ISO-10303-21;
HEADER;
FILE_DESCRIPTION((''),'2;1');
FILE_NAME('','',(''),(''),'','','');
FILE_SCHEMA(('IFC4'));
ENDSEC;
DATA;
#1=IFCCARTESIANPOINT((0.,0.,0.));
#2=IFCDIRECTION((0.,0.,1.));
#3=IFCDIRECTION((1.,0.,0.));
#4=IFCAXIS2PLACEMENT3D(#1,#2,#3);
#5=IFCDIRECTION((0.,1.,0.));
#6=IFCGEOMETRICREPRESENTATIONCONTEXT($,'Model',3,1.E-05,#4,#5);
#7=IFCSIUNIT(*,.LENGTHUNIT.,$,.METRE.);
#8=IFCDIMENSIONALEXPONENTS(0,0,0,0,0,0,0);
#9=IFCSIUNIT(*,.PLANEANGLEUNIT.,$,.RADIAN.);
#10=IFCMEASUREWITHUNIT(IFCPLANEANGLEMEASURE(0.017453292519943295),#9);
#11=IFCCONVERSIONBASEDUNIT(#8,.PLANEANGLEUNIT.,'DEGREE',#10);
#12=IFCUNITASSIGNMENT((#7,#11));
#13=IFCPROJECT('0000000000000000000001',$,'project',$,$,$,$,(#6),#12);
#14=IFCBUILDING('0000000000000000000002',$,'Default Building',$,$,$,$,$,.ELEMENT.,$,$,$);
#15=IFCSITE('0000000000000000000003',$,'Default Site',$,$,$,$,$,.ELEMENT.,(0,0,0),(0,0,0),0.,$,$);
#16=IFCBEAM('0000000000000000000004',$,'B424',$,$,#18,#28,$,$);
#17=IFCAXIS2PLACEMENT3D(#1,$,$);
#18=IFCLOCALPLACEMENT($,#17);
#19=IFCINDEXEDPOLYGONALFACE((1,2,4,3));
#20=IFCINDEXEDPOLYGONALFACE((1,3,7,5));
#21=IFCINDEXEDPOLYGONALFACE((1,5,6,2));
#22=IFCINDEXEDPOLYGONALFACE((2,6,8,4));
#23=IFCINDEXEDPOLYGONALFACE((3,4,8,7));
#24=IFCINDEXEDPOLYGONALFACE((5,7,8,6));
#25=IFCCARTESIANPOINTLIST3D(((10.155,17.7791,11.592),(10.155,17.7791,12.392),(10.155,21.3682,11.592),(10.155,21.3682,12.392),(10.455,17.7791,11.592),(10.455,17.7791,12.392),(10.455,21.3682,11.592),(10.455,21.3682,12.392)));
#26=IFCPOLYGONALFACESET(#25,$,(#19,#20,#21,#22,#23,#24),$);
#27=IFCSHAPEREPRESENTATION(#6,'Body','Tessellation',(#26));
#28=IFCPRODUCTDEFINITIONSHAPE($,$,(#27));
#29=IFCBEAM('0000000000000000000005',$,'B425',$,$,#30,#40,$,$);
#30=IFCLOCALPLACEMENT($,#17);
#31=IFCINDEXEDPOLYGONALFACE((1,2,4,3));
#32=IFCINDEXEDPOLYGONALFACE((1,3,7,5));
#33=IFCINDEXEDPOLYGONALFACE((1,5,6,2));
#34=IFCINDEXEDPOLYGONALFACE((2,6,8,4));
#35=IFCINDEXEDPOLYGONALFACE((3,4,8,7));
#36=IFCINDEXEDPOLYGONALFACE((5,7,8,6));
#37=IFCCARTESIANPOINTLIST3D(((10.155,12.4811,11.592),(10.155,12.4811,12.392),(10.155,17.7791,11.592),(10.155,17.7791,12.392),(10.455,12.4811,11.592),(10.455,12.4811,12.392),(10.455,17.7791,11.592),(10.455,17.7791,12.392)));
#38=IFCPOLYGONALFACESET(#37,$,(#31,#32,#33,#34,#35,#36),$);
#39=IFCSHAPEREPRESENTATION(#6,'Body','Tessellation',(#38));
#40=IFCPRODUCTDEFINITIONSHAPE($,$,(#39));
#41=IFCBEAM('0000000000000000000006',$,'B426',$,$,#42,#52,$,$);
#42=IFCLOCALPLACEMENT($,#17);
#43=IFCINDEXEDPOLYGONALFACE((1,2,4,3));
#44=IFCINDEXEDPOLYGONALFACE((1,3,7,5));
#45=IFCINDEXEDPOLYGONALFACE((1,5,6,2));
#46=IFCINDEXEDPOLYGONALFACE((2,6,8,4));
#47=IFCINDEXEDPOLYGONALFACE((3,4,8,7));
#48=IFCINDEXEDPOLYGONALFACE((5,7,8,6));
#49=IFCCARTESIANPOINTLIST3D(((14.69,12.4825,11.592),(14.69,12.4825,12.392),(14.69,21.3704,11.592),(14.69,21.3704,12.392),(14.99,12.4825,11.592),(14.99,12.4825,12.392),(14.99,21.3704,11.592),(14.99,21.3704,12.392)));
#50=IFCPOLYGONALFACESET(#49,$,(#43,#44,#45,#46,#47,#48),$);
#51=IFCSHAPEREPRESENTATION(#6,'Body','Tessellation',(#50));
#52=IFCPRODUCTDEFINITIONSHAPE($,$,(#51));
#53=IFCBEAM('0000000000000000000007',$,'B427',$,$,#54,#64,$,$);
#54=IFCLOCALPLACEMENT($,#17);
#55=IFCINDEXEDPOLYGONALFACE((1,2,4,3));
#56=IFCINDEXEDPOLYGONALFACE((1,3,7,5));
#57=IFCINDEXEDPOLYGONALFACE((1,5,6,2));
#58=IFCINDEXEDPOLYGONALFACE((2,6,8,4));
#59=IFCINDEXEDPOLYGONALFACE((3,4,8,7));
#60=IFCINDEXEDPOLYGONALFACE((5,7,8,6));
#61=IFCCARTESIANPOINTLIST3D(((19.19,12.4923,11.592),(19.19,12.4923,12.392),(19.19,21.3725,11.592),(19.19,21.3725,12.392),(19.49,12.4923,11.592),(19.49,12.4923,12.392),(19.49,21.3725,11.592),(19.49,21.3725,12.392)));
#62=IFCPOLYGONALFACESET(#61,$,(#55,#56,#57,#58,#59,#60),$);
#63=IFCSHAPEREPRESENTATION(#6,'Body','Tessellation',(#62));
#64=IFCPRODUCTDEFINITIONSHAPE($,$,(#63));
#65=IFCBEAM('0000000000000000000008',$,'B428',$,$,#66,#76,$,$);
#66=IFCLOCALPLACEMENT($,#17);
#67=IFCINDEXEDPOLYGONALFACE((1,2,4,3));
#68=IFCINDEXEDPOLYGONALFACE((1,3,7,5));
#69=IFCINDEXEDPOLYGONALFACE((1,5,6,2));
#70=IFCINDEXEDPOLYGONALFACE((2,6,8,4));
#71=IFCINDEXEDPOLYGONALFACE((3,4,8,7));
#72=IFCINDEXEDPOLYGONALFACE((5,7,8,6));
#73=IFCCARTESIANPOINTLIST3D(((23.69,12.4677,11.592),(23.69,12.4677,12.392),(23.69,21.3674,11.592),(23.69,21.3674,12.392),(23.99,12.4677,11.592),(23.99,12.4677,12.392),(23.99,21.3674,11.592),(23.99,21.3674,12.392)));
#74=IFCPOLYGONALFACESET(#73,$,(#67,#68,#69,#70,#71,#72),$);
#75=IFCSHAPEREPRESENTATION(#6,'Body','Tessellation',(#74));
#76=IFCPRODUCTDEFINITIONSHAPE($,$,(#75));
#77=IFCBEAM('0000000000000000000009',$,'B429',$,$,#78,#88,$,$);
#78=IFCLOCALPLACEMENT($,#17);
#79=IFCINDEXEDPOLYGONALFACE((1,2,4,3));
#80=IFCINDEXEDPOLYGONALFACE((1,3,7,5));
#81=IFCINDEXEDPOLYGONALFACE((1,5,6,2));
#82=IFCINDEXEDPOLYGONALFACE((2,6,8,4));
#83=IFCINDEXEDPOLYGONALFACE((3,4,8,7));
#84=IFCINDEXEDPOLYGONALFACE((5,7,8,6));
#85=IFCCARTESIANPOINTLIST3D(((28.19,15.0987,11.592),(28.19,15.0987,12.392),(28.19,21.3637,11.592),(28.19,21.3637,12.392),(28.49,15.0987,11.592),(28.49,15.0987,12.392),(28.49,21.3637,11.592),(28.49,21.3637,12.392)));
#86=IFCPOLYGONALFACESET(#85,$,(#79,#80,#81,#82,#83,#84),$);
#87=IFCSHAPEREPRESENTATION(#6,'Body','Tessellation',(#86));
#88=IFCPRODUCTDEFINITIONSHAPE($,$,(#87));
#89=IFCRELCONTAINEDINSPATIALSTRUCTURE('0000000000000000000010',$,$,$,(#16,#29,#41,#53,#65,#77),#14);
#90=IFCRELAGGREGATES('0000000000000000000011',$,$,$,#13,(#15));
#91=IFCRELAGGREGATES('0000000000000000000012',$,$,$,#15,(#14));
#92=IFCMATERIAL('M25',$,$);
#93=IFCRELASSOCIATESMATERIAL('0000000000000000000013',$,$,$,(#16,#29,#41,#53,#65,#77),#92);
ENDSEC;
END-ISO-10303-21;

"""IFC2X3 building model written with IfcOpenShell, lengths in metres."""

from ifc_helpers import new_model, entity, si_unit, converted_unit, direction, frame, frame_2d, origin_with_axes, place, context, project, spatial, rectangle, extrude, material, element, save


model = new_model("IFC2X3")

# Units and contexts
model_context = context("Model", 3, precision=1e-05, world=origin_with_axes(), true_north=direction((0.0, 1.0, 0.0)))
ifc_project = project(units=[si_unit("LENGTHUNIT", "METRE"), converted_unit("PLANEANGLEUNIT", "DEGREE", entity("IfcPlaneAngleMeasure", 0.017453292519943295), si_unit("PLANEANGLEUNIT", "RADIAN"), dimensions=[0, 0, 0, 0, 0, 0, 0])], contexts=[model_context])

# Site, building
site = spatial("IfcSite", under=ifc_project, Name="Default Site", CompositionType="ELEMENT", RefLatitude=(0, 0, 0), RefLongitude=(0, 0, 0), RefElevation=0.0)
building = spatial("IfcBuilding", under=site, Name="Default Building", CompositionType="ELEMENT")

# Beams
ifc_material = material(Name="M25")
placement = place(None, origin_with_axes())
element("IfcBeam", 1, at=placement, inside=building, material=ifc_material, Name="B424", context=model_context, shape_type="SweptSolid", body=[
    extrude(rectangle(XDim=0.3, YDim=0.8, at=frame_2d((0.0, 0.0), x_axis=(0.0, 1.0, 0.0))), frame((10.305, 21.3682, 11.992), z_axis=(0.0, -1.0, 0.0), x_axis=(0.0, 0.0, -1.0)), (0.0, 0.0, 1.0), 3.5891),
])
element("IfcBeam", 2, at=placement, inside=building, material=ifc_material, Name="B425", context=model_context, shape_type="SweptSolid", body=[
    extrude(rectangle(XDim=0.3, YDim=0.8, at=frame_2d((0.0, 0.0), x_axis=(0.0, 1.0, 0.0))), frame((10.305, 17.7791, 11.992), z_axis=(0.0, -1.0, 0.0), x_axis=(0.0, 0.0, -1.0)), (0.0, 0.0, 1.0), 5.298),
])
element("IfcBeam", 3, at=placement, inside=building, material=ifc_material, Name="B426", context=model_context, shape_type="SweptSolid", body=[
    extrude(rectangle(XDim=0.3, YDim=0.8, at=frame_2d((0.0, 0.0), x_axis=(0.0, 1.0, 0.0))), frame((14.84, 21.3704, 11.992), z_axis=(0.0, -1.0, 0.0), x_axis=(0.0, 0.0, -1.0)), (0.0, 0.0, 1.0), 8.8879),
])
element("IfcBeam", 4, at=placement, inside=building, material=ifc_material, Name="B427", context=model_context, shape_type="SweptSolid", body=[
    extrude(rectangle(XDim=0.3, YDim=0.8, at=frame_2d((0.0, 0.0), x_axis=(0.0, 1.0, 0.0))), frame((19.34, 21.3725, 11.992), z_axis=(0.0, -1.0, 0.0), x_axis=(0.0, 0.0, -1.0)), (0.0, 0.0, 1.0), 8.8802),
])
element("IfcBeam", 5, at=placement, inside=building, material=ifc_material, Name="B428", context=model_context, shape_type="SweptSolid", body=[
    extrude(rectangle(XDim=0.3, YDim=0.8, at=frame_2d((0.0, 0.0), x_axis=(0.0, 1.0, 0.0))), frame((23.84, 21.3674, 11.992), z_axis=(0.0, -1.0, 0.0), x_axis=(0.0, 0.0, -1.0)), (0.0, 0.0, 1.0), 8.8997),
])
element("IfcBeam", 6, at=placement, inside=building, material=ifc_material, Name="B429", context=model_context, shape_type="SweptSolid", body=[
    extrude(rectangle(XDim=0.3, YDim=0.8, at=frame_2d((0.0, 0.0), x_axis=(0.0, 1.0, 0.0))), frame((28.34, 21.3637, 11.992), z_axis=(0.0, -1.0, 0.0), x_axis=(0.0, 0.0, -1.0)), (0.0, 0.0, 1.0), 6.265),
])

save(model, "model.ifc")
